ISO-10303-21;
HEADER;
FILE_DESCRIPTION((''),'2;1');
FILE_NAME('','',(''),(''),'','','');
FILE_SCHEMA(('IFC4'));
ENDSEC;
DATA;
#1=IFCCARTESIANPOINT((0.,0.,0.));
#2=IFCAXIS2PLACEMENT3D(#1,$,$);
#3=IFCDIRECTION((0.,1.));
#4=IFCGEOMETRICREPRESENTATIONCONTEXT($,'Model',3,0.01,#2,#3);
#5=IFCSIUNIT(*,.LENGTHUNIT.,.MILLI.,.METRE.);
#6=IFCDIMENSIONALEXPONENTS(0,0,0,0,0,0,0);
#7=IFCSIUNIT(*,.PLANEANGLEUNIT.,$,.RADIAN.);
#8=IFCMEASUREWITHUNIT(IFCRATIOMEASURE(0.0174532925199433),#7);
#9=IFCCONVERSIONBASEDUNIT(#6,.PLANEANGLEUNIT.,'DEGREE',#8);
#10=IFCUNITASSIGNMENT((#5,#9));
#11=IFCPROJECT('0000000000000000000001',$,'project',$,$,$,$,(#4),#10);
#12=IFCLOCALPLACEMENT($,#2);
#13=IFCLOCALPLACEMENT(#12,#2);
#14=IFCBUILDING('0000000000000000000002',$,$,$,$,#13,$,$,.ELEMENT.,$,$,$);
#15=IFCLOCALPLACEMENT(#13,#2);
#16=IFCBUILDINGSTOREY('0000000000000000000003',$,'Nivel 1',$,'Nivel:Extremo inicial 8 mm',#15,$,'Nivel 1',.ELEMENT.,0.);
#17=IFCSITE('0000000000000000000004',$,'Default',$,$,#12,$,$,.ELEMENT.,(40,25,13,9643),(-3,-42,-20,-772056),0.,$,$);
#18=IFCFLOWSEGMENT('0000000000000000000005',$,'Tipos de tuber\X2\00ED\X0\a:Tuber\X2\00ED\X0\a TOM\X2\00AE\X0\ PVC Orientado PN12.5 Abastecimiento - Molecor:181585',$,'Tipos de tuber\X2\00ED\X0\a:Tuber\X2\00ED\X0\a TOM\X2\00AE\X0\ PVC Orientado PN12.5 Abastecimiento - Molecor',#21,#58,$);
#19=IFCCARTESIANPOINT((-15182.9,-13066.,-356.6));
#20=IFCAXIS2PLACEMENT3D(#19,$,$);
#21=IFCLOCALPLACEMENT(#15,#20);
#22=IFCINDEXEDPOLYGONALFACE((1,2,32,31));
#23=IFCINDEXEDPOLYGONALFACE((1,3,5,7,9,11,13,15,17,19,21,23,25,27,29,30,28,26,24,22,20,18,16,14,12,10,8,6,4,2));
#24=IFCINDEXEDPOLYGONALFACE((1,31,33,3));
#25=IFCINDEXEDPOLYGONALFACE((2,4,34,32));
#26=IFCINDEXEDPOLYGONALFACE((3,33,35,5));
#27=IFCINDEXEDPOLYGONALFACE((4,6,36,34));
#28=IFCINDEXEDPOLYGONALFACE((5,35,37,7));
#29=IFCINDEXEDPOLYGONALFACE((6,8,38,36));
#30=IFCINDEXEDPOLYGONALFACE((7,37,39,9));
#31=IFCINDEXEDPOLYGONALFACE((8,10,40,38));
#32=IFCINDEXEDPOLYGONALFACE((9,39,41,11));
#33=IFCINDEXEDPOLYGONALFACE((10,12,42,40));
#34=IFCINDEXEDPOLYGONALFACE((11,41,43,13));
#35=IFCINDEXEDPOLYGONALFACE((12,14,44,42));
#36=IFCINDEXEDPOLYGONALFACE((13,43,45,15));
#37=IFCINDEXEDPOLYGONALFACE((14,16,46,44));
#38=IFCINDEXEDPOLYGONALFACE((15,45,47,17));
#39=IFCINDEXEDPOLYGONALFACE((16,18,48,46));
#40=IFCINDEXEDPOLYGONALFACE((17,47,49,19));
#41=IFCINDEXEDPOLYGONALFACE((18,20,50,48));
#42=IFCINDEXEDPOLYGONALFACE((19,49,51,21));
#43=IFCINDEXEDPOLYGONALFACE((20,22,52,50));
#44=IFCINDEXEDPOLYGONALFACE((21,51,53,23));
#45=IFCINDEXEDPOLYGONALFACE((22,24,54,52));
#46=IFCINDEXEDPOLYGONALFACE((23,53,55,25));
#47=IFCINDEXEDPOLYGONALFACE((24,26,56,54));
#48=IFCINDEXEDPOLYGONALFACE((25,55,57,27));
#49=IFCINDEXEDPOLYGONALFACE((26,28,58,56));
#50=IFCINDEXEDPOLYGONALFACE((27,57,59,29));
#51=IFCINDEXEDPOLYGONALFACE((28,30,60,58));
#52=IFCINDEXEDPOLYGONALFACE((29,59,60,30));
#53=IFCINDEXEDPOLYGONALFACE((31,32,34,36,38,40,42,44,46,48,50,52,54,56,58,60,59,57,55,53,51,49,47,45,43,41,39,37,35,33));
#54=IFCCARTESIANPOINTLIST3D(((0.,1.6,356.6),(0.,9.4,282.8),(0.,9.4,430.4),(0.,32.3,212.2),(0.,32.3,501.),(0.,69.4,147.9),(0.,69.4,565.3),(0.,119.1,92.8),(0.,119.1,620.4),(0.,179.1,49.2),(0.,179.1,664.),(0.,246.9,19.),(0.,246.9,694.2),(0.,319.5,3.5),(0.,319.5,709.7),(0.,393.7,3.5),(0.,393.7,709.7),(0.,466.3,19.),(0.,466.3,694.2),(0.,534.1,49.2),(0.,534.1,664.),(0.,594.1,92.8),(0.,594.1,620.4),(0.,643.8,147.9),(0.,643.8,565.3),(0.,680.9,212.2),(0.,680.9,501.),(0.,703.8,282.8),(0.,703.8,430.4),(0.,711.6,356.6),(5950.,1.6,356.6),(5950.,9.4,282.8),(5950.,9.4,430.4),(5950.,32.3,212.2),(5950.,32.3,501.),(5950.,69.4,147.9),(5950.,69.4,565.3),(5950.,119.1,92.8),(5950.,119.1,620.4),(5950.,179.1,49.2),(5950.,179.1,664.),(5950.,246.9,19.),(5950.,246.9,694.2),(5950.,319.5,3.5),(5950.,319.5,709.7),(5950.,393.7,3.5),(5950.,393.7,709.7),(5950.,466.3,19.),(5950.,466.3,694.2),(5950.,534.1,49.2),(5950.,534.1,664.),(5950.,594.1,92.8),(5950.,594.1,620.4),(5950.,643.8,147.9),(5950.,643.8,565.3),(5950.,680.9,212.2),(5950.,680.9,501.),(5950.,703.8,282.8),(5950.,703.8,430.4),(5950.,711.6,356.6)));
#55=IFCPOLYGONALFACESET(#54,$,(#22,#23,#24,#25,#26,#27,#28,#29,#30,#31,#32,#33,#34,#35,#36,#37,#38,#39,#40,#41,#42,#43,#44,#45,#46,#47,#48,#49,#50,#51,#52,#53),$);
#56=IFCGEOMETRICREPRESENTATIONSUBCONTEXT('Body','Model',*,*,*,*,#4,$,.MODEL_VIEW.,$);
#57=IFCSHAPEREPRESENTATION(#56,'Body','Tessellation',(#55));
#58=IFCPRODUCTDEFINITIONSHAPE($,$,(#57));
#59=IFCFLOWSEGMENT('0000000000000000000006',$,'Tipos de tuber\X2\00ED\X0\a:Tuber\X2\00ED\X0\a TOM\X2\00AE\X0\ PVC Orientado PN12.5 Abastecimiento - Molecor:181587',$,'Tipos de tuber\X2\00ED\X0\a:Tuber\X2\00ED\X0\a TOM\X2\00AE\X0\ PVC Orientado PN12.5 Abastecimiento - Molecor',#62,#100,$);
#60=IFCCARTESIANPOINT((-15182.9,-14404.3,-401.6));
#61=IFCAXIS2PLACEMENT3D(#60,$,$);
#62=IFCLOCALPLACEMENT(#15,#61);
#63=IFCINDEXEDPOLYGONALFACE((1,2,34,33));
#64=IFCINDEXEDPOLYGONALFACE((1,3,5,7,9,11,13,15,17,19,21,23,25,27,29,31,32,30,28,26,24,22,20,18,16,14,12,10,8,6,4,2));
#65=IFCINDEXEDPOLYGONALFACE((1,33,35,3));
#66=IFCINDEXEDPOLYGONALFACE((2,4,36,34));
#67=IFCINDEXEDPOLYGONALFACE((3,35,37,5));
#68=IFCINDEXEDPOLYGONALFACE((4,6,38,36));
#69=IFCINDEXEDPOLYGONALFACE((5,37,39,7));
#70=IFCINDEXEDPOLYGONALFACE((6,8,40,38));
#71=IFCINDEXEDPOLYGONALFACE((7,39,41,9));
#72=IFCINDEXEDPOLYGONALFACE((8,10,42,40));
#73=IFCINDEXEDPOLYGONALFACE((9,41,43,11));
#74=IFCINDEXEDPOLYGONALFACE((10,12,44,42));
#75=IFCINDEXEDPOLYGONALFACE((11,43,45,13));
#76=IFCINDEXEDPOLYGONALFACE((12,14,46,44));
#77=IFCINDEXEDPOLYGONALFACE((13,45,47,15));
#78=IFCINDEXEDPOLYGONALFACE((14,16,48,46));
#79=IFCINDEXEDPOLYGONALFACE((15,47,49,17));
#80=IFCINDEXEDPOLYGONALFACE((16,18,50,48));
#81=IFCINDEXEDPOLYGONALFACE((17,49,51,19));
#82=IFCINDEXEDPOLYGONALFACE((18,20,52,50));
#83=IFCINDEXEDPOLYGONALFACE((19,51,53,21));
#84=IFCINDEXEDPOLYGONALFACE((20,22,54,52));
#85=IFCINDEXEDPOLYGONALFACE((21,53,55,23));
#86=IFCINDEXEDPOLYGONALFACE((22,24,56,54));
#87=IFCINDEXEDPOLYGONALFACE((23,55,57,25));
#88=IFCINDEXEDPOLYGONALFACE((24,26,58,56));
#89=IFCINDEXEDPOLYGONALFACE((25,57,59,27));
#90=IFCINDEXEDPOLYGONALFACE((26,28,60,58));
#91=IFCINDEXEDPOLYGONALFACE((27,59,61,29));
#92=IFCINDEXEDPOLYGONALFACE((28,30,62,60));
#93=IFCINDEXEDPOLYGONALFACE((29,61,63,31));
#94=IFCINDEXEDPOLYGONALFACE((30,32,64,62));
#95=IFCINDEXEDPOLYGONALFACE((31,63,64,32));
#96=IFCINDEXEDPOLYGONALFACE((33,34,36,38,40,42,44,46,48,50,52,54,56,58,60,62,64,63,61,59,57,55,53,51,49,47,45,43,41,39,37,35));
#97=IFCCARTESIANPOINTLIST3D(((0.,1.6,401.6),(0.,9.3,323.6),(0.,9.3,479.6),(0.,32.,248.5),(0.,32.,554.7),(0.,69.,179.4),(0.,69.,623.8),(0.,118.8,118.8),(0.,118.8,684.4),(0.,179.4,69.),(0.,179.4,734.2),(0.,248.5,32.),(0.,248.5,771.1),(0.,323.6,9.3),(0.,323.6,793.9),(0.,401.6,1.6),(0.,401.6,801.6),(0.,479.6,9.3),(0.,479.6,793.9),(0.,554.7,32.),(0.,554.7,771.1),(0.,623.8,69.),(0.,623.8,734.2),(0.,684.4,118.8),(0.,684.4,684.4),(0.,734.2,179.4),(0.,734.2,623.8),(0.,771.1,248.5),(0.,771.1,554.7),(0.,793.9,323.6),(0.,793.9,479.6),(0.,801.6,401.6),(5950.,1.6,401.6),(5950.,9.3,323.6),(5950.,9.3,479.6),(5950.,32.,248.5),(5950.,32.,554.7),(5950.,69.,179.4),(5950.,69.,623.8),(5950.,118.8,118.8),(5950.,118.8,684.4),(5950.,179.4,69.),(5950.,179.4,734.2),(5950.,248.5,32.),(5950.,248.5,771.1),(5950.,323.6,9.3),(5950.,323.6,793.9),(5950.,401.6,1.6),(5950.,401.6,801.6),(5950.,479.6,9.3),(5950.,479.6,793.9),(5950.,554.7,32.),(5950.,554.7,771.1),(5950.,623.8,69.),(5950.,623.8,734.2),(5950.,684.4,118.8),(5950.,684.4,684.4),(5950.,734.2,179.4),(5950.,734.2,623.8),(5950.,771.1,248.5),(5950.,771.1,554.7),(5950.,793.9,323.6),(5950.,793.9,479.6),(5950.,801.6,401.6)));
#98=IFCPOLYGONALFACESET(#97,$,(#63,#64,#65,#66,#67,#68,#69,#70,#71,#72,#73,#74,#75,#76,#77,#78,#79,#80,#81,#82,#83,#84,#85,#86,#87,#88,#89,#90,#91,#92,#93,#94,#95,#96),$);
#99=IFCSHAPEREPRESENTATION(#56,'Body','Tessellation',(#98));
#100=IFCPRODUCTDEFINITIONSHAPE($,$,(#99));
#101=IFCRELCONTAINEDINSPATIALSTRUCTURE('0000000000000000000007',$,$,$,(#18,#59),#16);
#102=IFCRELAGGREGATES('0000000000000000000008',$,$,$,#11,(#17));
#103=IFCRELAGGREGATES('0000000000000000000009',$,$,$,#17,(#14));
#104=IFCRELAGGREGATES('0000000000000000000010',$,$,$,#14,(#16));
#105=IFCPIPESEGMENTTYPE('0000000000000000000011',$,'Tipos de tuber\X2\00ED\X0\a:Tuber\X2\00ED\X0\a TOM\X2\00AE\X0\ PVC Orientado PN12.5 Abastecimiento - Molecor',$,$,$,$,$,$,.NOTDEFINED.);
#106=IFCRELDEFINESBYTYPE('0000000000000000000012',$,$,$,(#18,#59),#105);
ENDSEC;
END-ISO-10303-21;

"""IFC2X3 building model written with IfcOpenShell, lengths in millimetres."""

from ifc_helpers import new_model, entity, si_unit, converted_unit, direction, frame, frame_2d, origin, place, context, subcontext, project, spatial, circle, extrude, type_object, element, save


model = new_model("IFC2X3")

# Units and contexts
model_context = context("Model", 3, precision=0.01, world=origin(), true_north=direction((0.0, 1.0)))
body_context = subcontext(model_context, "Body", "Model", "MODEL_VIEW")
ifc_project = project(units=[si_unit("LENGTHUNIT", "METRE", prefix="MILLI"), converted_unit("PLANEANGLEUNIT", "DEGREE", entity("IfcRatioMeasure", 0.0174532925199433), si_unit("PLANEANGLEUNIT", "RADIAN"), dimensions=[0, 0, 0, 0, 0, 0, 0])], contexts=[model_context])

# Site, building, storey
site_placement = place(None, origin())
site = spatial("IfcSite", under=ifc_project, at=site_placement, Name="Default", CompositionType="ELEMENT", RefLatitude=(40, 25, 13, 9643), RefLongitude=(-3, -42, -20, -772056), RefElevation=0.0)
building_placement = place(site_placement, origin())
building = spatial("IfcBuilding", under=site, at=building_placement, CompositionType="ELEMENT")
storey_placement = place(building_placement, origin())
storey = spatial("IfcBuildingStorey", under=building, at=storey_placement, Name="Nivel 1", ObjectType="Nivel:Extremo inicial 8 mm", LongName="Nivel 1", CompositionType="ELEMENT", Elevation=0.0)

# Flow segments
pipe_segment_type = type_object("IfcPipeSegmentType", Name="Tipos de tubería:Tubería TOM® PVC Orientado PN12.5 Abastecimiento - Molecor", PredefinedType="NOTDEFINED")
flow_segment_1_placement = place(storey_placement, frame((-15182.9, -13066.0, -356.6)))
element("IfcFlowSegment", 1, at=flow_segment_1_placement, inside=storey, type_object=pipe_segment_type, Name="Tipos de tubería:Tubería TOM® PVC Orientado PN12.5 Abastecimiento - Molecor:181585", ObjectType="Tipos de tubería:Tubería TOM® PVC Orientado PN12.5 Abastecimiento - Molecor", context=body_context, shape_type="SweptSolid", body=[
    extrude(circle(Radius=355.0, at=frame_2d((0.0, 0.0), x_axis=(1.0, 0.0))), frame((0.0, 356.6, 356.6), z_axis=(1.0, 0.0, 0.0), x_axis=(0.0, -1.0, 0.0)), (0.0, 0.0, 1.0), 5950.0),
])
flow_segment_2_placement = place(storey_placement, frame((-15182.9, -14404.3, -401.6)))
element("IfcFlowSegment", 2, at=flow_segment_2_placement, inside=storey, type_object=pipe_segment_type, Name="Tipos de tubería:Tubería TOM® PVC Orientado PN12.5 Abastecimiento - Molecor:181587", ObjectType="Tipos de tubería:Tubería TOM® PVC Orientado PN12.5 Abastecimiento - Molecor", context=body_context, shape_type="SweptSolid", body=[
    extrude(circle(Radius=400.0, at=frame_2d((0.0, 0.0), x_axis=(1.0, 0.0))), frame((0.0, 401.6, 401.6), z_axis=(1.0, 0.0, 0.0), x_axis=(0.0, -1.0, 0.0)), (0.0, 0.0, 1.0), 5950.0),
])

save(model, "model.ifc")
